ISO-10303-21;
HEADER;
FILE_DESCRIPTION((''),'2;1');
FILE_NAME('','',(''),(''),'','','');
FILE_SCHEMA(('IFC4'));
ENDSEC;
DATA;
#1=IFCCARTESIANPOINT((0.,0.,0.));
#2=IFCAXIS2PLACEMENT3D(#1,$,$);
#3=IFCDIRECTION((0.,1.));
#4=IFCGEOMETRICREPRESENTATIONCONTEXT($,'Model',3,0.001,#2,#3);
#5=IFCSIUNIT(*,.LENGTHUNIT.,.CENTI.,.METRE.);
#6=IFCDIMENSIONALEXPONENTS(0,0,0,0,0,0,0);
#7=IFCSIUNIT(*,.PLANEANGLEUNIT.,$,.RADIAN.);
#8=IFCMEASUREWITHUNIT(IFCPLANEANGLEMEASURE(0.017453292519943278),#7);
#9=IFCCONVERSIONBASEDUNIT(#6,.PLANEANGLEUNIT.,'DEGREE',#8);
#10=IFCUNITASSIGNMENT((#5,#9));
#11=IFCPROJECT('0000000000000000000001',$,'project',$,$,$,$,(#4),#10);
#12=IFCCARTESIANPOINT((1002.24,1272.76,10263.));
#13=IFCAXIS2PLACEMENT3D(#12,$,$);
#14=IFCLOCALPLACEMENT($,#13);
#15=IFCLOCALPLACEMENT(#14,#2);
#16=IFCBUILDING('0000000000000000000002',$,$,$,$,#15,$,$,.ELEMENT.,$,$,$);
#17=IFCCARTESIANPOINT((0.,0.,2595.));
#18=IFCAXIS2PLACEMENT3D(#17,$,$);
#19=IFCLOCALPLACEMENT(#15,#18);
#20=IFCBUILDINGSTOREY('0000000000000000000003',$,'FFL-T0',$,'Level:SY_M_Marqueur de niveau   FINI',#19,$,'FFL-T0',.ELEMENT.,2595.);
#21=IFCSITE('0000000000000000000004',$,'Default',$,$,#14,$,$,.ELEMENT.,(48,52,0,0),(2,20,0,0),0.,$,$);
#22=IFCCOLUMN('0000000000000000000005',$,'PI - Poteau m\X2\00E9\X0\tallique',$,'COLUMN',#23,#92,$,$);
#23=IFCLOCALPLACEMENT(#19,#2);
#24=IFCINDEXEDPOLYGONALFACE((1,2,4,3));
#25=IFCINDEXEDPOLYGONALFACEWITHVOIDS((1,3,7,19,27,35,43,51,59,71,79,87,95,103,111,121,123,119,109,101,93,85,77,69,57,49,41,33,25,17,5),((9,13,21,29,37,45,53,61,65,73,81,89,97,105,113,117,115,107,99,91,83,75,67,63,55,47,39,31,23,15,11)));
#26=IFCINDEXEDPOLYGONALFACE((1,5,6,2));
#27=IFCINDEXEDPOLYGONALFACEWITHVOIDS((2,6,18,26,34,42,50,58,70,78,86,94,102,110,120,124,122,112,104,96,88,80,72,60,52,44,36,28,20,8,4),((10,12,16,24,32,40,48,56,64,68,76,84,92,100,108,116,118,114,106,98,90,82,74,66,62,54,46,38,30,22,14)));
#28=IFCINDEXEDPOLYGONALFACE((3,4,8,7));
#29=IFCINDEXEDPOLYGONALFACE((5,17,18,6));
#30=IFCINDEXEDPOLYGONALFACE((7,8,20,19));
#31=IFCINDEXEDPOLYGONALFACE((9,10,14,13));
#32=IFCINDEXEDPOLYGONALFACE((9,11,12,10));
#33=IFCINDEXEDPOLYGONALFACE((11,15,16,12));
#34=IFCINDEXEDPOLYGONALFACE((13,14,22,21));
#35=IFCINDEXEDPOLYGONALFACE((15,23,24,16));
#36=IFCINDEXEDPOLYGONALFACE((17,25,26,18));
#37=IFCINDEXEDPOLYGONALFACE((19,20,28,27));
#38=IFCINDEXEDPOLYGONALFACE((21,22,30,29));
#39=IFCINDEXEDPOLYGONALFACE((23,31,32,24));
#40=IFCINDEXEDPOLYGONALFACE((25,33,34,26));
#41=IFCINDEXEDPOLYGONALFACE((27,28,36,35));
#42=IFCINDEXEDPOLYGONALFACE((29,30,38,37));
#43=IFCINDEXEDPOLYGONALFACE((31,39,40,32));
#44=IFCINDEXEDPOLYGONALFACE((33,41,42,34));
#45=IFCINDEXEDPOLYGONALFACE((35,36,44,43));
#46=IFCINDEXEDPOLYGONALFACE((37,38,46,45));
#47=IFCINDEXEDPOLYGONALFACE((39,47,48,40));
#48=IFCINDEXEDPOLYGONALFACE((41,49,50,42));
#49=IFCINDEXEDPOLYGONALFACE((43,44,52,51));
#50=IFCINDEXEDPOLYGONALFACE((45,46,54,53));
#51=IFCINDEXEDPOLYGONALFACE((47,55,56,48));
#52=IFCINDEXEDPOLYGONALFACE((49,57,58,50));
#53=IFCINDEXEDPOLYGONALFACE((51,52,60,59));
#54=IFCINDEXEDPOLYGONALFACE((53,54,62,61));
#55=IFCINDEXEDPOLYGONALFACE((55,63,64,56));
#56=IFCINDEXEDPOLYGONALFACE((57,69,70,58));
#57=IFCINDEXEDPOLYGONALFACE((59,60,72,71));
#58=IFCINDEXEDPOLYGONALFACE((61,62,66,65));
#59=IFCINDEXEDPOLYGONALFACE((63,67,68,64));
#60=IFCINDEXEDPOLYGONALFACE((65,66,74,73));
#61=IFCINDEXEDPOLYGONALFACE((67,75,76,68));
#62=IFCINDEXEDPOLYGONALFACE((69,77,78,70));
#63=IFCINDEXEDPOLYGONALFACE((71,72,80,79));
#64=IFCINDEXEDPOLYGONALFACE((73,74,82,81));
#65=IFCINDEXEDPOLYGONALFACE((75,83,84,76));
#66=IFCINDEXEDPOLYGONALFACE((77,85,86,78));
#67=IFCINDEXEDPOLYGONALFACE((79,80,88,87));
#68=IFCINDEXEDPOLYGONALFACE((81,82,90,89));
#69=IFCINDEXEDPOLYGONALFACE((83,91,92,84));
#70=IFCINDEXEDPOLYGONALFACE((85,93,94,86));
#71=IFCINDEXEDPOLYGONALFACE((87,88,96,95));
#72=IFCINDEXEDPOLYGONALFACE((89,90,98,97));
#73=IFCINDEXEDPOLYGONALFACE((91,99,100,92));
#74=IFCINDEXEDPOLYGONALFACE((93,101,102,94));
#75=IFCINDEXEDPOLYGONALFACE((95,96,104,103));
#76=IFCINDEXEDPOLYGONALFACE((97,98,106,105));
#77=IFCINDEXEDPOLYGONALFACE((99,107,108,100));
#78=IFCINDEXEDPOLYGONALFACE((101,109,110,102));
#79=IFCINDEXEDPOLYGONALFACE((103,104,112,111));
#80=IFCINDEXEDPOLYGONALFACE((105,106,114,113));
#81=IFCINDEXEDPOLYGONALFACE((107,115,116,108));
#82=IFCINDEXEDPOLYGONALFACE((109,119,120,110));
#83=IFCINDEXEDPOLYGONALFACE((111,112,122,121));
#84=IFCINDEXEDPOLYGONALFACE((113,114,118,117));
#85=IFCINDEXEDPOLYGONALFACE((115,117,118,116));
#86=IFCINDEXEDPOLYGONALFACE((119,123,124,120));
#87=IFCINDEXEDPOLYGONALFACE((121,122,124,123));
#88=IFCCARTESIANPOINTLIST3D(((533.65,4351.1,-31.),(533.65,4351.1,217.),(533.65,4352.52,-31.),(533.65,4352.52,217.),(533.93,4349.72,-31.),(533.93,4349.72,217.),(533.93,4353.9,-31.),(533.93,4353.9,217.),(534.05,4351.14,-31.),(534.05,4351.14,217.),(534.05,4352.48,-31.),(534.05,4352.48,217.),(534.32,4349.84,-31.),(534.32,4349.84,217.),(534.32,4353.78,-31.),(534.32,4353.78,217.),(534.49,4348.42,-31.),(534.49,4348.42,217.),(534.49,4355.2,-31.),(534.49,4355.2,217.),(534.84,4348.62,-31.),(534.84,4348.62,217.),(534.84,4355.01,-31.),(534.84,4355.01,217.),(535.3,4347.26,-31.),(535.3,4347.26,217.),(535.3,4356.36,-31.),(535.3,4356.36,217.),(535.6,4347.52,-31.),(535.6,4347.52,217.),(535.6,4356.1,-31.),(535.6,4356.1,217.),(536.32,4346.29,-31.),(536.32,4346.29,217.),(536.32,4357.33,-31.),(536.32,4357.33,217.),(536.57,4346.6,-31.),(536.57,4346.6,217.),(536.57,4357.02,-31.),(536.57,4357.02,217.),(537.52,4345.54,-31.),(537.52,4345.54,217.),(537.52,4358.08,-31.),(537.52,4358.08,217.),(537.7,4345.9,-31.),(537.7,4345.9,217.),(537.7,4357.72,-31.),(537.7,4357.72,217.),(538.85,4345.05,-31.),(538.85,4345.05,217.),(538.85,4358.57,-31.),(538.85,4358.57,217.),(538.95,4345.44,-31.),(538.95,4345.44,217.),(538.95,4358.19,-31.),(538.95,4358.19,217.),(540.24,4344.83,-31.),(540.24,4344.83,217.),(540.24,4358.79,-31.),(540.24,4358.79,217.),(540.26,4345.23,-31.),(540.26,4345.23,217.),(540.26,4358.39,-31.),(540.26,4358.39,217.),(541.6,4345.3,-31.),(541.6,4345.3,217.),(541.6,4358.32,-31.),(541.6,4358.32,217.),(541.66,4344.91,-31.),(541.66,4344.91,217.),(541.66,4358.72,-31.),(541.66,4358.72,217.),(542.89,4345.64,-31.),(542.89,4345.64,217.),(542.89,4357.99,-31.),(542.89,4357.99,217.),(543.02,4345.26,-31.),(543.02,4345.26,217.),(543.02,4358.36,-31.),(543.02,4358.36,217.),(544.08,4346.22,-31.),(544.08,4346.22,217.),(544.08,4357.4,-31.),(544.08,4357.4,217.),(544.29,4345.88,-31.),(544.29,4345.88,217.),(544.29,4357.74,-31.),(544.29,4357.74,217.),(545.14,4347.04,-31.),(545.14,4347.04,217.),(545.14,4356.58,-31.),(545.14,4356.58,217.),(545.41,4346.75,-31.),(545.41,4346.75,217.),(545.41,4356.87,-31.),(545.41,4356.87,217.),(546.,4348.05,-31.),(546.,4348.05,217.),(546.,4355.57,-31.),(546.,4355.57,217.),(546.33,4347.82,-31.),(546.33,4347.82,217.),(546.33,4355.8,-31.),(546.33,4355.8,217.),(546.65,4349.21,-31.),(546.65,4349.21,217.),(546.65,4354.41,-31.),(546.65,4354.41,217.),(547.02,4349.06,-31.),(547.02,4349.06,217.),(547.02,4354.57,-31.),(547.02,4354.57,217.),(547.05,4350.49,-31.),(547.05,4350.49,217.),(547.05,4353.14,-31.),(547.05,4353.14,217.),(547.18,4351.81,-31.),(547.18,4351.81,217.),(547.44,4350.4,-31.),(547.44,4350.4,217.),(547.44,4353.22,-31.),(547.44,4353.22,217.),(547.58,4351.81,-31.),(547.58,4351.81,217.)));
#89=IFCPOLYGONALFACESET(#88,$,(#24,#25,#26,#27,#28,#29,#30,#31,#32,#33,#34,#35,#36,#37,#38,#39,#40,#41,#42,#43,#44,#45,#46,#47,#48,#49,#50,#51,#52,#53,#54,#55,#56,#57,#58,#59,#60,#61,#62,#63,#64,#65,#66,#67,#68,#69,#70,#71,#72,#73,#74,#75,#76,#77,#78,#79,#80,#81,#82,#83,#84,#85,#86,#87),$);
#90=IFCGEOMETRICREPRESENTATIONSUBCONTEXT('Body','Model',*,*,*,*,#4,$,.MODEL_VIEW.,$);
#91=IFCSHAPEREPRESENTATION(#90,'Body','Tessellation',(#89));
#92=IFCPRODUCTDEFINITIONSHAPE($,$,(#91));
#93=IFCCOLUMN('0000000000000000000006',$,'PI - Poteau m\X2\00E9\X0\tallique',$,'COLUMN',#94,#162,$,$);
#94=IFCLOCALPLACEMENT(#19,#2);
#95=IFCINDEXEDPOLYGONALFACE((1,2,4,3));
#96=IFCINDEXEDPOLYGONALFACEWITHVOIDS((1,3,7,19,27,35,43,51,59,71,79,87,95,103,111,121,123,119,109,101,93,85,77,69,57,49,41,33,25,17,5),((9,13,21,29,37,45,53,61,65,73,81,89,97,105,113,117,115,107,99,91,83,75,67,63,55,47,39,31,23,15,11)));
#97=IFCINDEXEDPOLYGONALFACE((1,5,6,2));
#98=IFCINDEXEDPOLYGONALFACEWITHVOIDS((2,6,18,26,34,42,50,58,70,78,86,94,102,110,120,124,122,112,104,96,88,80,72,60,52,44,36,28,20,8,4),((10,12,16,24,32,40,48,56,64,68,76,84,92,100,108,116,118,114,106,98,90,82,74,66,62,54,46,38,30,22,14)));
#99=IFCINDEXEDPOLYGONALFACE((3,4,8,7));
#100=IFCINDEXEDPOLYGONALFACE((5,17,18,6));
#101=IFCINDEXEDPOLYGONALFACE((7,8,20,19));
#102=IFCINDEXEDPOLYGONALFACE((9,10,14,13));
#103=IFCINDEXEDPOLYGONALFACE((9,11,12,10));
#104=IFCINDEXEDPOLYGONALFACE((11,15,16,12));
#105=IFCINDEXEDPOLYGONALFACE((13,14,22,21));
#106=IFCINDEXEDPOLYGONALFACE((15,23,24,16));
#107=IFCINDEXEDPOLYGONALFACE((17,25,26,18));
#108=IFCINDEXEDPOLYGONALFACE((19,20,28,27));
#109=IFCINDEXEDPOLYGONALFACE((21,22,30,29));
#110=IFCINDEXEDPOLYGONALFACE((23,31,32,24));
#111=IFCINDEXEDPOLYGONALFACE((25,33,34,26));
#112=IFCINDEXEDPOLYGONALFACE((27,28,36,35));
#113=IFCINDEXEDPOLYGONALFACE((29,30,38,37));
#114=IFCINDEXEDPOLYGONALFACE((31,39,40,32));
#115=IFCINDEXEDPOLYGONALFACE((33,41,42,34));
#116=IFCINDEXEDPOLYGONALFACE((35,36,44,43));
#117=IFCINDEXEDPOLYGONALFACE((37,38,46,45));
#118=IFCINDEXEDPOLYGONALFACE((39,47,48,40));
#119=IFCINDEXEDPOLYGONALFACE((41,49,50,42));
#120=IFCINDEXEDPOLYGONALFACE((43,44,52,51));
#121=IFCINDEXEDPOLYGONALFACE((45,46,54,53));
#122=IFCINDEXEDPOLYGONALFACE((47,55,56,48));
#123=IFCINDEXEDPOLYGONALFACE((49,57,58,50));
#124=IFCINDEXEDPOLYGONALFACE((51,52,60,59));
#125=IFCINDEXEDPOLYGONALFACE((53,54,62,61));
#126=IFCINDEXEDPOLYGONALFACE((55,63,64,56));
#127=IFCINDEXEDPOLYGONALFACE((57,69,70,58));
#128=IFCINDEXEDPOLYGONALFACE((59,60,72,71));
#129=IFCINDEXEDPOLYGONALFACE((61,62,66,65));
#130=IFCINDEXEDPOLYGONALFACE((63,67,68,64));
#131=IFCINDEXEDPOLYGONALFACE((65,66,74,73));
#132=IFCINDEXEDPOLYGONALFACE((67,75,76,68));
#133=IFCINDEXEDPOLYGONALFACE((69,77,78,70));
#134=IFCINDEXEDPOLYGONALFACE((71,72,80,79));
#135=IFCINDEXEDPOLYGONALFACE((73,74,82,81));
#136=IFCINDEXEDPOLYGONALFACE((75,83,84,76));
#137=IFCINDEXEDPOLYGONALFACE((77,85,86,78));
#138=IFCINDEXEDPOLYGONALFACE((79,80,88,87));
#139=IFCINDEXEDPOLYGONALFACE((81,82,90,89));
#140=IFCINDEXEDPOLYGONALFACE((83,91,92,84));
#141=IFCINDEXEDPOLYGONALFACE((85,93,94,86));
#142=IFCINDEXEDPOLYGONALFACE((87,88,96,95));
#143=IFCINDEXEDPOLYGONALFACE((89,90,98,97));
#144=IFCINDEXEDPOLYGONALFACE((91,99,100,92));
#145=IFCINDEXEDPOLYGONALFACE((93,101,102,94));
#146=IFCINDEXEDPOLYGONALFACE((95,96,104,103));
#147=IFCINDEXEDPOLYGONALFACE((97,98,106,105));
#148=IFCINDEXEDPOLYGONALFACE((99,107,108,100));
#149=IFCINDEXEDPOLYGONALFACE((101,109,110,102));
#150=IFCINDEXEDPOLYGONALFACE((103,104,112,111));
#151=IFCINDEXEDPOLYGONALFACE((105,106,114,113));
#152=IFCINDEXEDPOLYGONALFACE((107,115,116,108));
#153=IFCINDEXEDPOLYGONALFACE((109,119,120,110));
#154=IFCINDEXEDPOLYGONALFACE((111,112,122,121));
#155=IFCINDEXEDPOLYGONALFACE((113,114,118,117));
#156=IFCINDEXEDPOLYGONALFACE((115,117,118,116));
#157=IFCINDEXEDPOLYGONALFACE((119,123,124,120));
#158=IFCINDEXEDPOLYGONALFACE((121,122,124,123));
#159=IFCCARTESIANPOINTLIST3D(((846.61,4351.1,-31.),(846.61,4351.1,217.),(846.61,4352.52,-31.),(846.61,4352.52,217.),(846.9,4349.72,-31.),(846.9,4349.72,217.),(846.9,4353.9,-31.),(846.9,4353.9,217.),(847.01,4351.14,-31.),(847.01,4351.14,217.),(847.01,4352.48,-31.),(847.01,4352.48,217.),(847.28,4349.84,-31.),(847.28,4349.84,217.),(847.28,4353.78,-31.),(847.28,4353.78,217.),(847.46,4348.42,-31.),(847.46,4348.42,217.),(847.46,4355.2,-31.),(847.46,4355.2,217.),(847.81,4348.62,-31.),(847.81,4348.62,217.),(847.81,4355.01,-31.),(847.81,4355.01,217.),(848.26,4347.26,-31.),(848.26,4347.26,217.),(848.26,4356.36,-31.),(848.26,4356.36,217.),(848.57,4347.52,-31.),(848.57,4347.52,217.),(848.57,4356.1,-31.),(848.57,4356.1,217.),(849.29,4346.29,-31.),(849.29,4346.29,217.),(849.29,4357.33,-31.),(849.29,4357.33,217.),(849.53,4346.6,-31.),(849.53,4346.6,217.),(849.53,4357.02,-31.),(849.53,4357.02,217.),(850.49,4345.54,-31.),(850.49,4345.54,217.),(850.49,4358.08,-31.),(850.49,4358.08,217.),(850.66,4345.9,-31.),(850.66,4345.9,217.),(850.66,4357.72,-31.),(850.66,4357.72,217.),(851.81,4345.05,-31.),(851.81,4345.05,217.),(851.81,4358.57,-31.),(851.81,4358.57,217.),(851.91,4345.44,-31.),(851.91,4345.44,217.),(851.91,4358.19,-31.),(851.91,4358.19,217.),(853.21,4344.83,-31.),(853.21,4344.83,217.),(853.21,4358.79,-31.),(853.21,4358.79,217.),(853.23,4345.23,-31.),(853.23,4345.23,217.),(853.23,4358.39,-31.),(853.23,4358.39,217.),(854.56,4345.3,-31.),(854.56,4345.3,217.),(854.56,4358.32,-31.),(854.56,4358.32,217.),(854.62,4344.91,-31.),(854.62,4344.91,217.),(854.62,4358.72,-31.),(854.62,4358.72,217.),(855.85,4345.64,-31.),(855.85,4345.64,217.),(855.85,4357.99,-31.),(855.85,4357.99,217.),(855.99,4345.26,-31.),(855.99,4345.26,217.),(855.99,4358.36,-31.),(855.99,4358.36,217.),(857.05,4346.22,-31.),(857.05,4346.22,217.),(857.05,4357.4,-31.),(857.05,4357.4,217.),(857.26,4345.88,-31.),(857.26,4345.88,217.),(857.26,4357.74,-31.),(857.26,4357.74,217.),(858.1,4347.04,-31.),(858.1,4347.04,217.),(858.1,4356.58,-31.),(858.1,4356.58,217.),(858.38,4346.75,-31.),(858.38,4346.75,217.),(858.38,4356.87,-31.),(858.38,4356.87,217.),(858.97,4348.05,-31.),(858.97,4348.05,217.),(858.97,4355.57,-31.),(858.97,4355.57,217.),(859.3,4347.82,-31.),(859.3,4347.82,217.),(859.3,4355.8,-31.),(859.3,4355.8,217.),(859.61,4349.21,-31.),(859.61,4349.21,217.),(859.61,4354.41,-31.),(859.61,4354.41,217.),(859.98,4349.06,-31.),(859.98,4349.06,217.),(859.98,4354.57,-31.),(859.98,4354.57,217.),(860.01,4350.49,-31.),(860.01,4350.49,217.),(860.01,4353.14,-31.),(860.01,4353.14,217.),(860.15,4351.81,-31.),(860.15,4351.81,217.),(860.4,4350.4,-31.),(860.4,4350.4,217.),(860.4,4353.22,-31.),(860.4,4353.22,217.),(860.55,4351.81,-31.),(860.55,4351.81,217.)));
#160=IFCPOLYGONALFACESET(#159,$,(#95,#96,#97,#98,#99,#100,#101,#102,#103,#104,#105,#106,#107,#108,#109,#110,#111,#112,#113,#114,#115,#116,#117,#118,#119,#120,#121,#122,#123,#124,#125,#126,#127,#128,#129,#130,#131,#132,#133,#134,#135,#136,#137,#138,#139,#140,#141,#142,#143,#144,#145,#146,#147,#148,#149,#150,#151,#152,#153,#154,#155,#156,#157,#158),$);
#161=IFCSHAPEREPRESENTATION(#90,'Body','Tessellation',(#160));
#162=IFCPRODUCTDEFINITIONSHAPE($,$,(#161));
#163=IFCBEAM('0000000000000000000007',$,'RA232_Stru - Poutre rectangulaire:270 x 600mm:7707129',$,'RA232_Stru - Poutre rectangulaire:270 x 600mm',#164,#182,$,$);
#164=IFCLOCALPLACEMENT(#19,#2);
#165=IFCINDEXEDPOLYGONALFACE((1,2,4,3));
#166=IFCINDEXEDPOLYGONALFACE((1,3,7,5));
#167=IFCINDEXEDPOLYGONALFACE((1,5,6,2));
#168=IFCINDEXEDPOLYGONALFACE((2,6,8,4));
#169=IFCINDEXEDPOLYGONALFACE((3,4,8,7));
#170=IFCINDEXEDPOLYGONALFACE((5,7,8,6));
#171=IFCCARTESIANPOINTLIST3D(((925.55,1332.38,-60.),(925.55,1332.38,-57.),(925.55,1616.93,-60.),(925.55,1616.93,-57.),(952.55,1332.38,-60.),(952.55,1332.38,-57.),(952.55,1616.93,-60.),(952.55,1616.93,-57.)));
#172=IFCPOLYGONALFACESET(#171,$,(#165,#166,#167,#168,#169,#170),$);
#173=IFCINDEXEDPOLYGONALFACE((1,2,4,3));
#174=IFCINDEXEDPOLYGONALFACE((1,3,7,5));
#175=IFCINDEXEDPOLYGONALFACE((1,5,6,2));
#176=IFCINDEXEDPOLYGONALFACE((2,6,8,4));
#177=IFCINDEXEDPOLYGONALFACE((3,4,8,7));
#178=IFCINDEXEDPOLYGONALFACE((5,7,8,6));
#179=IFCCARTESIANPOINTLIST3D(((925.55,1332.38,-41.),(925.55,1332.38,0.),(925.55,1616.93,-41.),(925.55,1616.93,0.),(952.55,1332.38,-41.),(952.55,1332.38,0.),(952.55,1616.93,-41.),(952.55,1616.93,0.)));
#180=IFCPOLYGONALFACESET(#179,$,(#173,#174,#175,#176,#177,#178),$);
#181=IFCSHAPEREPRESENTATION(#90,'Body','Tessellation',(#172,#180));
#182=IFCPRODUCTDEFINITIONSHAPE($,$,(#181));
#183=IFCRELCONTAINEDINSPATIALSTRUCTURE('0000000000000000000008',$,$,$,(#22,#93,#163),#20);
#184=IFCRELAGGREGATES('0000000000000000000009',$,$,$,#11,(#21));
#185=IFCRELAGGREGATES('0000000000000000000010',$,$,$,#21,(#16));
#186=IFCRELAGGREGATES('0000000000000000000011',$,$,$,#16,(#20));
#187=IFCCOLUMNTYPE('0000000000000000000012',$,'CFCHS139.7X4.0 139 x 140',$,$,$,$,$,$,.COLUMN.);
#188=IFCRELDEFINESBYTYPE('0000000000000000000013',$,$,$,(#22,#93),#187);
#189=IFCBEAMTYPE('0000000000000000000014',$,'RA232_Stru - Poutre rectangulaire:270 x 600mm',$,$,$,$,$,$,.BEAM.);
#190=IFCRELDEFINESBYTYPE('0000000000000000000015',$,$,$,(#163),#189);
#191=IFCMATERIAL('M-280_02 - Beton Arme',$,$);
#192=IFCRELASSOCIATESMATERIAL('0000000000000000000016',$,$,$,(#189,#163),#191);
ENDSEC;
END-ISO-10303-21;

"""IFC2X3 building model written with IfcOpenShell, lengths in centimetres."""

from ifc_helpers import new_model, entity, si_unit, converted_unit, direction, frame, frame_2d, origin, place, context, subcontext, project, spatial, polyline, rectangle, outline, extrude, source, transform, mapped, material, type_object, type_shapes, element, save


model = new_model("IFC2X3")

# Units and contexts
model_context = context("Model", 3, precision=0.001, world=origin(), true_north=direction((0.0, 1.0)))
body_context = subcontext(model_context, "Body", "Model", "MODEL_VIEW")
ifc_project = project(units=[si_unit("LENGTHUNIT", "METRE", prefix="CENTI"), converted_unit("PLANEANGLEUNIT", "DEGREE", entity("IfcPlaneAngleMeasure", 0.017453292519943278), si_unit("PLANEANGLEUNIT", "RADIAN"), dimensions=[0, 0, 0, 0, 0, 0, 0])], contexts=[model_context])

# Site, building, storey
site_placement = place(None, frame((1002.24, 1272.76, 10263.0)))
site = spatial("IfcSite", under=ifc_project, at=site_placement, Name="Default", CompositionType="ELEMENT", RefLatitude=(48, 52, 0, 0), RefLongitude=(2, 20, 0, 0), RefElevation=0.0)
building_placement = place(site_placement, origin())
building = spatial("IfcBuilding", under=site, at=building_placement, CompositionType="ELEMENT")
storey_placement = place(building_placement, frame((0.0, 0.0, 2595.0)))
storey = spatial("IfcBuildingStorey", under=building, at=storey_placement, Name="FFL-T0", ObjectType="Level:SY_M_Marqueur de niveau   FINI", LongName="FFL-T0", CompositionType="ELEMENT", Elevation=2595.0)

# Columns
column_type = type_object("IfcColumnType", Name="CFCHS139.7X4.0 139 x 140", PredefinedType="COLUMN")
column_1_placement = place(storey_placement, origin())
element("IfcColumn", 1, at=column_1_placement, inside=storey, type_object=column_type, Name="PI - Poteau métallique", ObjectType="COLUMN", context=body_context, shape_type="SweptSolid", body=[
    extrude(outline(polyline([(-0.71, -6.95), (0.71, -6.95), (2.09, -6.66), (3.39, -6.11), (4.55, -5.3), (5.52, -4.28), (6.27, -3.08), (6.76, -1.75), (6.98, -0.35), (6.9, 1.06), (6.55, 2.43), (5.93, 3.69), (5.06, 4.81), (3.99, 5.73), (2.75, 6.42), (1.41, 6.84), (0.0, 6.98), (-1.41, 6.84), (-2.75, 6.42), (-3.99, 5.73), (-5.06, 4.81), (-5.93, 3.69), (-6.55, 2.43), (-6.9, 1.06), (-6.98, -0.35), (-6.76, -1.75), (-6.27, -3.08), (-5.52, -4.28), (-4.55, -5.3), (-3.39, -6.11), (-2.09, -6.66), (-0.71, -6.95)]), holes=[polyline([(-5.21, -4.03), (-5.91, -2.9), (-6.37, -1.65), (-6.58, -0.33), (-6.51, 1.0), (-6.18, 2.29), (-5.59, 3.48), (-4.77, 4.54), (-3.76, 5.4), (-2.6, 6.05), (-1.33, 6.45), (0.0, 6.58), (1.33, 6.45), (2.6, 6.05), (3.76, 5.4), (4.77, 4.54), (5.59, 3.48), (6.18, 2.29), (6.51, 1.0), (6.58, -0.33), (6.37, -1.65), (5.91, -2.9), (5.21, -4.03), (4.29, -5.0), (3.2, -5.76), (1.97, -6.28), (0.67, -6.55), (-0.67, -6.55), (-1.97, -6.28), (-3.2, -5.76), (-4.29, -5.0), (-5.21, -4.03)])]), frame((540.6, 4351.81, -31.0), z_axis=(0.0, 0.0, 1.0), x_axis=(-0.485302, 0.874347, 0.0)), (0.0, 0.0, 1.0), 248.0),
])
column_2_placement = place(storey_placement, origin())
element("IfcColumn", 2, at=column_2_placement, inside=storey, type_object=column_type, Name="PI - Poteau métallique", ObjectType="COLUMN", context=body_context, shape_type="SweptSolid", body=[
    extrude(outline(polyline([(-0.71, -6.95), (0.71, -6.95), (2.09, -6.66), (3.39, -6.11), (4.55, -5.3), (5.52, -4.28), (6.27, -3.08), (6.76, -1.75), (6.98, -0.35), (6.9, 1.06), (6.55, 2.43), (5.93, 3.69), (5.06, 4.81), (3.99, 5.73), (2.75, 6.42), (1.41, 6.84), (0.0, 6.98), (-1.41, 6.84), (-2.75, 6.42), (-3.99, 5.73), (-5.06, 4.81), (-5.93, 3.69), (-6.55, 2.43), (-6.9, 1.06), (-6.98, -0.35), (-6.76, -1.75), (-6.27, -3.08), (-5.52, -4.28), (-4.55, -5.3), (-3.39, -6.11), (-2.09, -6.66), (-0.71, -6.95)]), holes=[polyline([(-5.21, -4.03), (-5.91, -2.9), (-6.37, -1.65), (-6.58, -0.33), (-6.51, 1.0), (-6.18, 2.29), (-5.59, 3.48), (-4.77, 4.54), (-3.76, 5.4), (-2.6, 6.05), (-1.33, 6.45), (0.0, 6.58), (1.33, 6.45), (2.6, 6.05), (3.76, 5.4), (4.77, 4.54), (5.59, 3.48), (6.18, 2.29), (6.51, 1.0), (6.58, -0.33), (6.37, -1.65), (5.91, -2.9), (5.21, -4.03), (4.29, -5.0), (3.2, -5.76), (1.97, -6.28), (0.67, -6.55), (-0.67, -6.55), (-1.97, -6.28), (-3.2, -5.76), (-4.29, -5.0), (-5.21, -4.03)])]), frame((853.56, 4351.81, -31.0), z_axis=(0.0, 0.0, 1.0), x_axis=(-0.485302, 0.874347, 0.0)), (0.0, 0.0, 1.0), 248.0),
])

# Beam
ifc_material_1 = material(Name="M-280_02 - Beton Arme")
beam_type_1 = type_object("IfcBeamType", Name="RA232_Stru - Poutre rectangulaire:270 x 600mm", PredefinedType="BEAM", material=ifc_material_1)
shared_shape_1 = source(origin(), body_context, "Body", "SweptSolid", [
    extrude(rectangle(XDim=3.0, YDim=27.0, at=frame_2d((0.0, 0.0), x_axis=(0.0, 1.0))), frame((939.05, 1616.93, 2536.5), z_axis=(0.0, -1.0, 0.0), x_axis=(-1.0, 0.0, 0.0)), (0.0, 0.0, 1.0), 284.55),
    extrude(rectangle(XDim=41.0, YDim=27.0, at=frame_2d((0.0, 0.0), x_axis=(0.0, 1.0))), frame((939.05, 1616.93, 2574.5), z_axis=(0.0, -1.0, 0.0), x_axis=(-1.0, 0.0, 0.0)), (0.0, 0.0, 1.0), 284.55),
])
type_shapes(beam_type_1, [shared_shape_1])
beam_1_placement = place(storey_placement, frame((0.0, 0.0, -2595.0)))
element("IfcBeam", 3, at=beam_1_placement, inside=storey, type_object=beam_type_1, material=ifc_material_1, Name="RA232_Stru - Poutre rectangulaire:270 x 600mm:7707129", ObjectType="RA232_Stru - Poutre rectangulaire:270 x 600mm", context=body_context, shape_type="MappedRepresentation", body=[
    mapped(shared_shape_1, transform((0.0, 0.0, 0.0), scale=1.0)),
])

save(model, "model.ifc")
